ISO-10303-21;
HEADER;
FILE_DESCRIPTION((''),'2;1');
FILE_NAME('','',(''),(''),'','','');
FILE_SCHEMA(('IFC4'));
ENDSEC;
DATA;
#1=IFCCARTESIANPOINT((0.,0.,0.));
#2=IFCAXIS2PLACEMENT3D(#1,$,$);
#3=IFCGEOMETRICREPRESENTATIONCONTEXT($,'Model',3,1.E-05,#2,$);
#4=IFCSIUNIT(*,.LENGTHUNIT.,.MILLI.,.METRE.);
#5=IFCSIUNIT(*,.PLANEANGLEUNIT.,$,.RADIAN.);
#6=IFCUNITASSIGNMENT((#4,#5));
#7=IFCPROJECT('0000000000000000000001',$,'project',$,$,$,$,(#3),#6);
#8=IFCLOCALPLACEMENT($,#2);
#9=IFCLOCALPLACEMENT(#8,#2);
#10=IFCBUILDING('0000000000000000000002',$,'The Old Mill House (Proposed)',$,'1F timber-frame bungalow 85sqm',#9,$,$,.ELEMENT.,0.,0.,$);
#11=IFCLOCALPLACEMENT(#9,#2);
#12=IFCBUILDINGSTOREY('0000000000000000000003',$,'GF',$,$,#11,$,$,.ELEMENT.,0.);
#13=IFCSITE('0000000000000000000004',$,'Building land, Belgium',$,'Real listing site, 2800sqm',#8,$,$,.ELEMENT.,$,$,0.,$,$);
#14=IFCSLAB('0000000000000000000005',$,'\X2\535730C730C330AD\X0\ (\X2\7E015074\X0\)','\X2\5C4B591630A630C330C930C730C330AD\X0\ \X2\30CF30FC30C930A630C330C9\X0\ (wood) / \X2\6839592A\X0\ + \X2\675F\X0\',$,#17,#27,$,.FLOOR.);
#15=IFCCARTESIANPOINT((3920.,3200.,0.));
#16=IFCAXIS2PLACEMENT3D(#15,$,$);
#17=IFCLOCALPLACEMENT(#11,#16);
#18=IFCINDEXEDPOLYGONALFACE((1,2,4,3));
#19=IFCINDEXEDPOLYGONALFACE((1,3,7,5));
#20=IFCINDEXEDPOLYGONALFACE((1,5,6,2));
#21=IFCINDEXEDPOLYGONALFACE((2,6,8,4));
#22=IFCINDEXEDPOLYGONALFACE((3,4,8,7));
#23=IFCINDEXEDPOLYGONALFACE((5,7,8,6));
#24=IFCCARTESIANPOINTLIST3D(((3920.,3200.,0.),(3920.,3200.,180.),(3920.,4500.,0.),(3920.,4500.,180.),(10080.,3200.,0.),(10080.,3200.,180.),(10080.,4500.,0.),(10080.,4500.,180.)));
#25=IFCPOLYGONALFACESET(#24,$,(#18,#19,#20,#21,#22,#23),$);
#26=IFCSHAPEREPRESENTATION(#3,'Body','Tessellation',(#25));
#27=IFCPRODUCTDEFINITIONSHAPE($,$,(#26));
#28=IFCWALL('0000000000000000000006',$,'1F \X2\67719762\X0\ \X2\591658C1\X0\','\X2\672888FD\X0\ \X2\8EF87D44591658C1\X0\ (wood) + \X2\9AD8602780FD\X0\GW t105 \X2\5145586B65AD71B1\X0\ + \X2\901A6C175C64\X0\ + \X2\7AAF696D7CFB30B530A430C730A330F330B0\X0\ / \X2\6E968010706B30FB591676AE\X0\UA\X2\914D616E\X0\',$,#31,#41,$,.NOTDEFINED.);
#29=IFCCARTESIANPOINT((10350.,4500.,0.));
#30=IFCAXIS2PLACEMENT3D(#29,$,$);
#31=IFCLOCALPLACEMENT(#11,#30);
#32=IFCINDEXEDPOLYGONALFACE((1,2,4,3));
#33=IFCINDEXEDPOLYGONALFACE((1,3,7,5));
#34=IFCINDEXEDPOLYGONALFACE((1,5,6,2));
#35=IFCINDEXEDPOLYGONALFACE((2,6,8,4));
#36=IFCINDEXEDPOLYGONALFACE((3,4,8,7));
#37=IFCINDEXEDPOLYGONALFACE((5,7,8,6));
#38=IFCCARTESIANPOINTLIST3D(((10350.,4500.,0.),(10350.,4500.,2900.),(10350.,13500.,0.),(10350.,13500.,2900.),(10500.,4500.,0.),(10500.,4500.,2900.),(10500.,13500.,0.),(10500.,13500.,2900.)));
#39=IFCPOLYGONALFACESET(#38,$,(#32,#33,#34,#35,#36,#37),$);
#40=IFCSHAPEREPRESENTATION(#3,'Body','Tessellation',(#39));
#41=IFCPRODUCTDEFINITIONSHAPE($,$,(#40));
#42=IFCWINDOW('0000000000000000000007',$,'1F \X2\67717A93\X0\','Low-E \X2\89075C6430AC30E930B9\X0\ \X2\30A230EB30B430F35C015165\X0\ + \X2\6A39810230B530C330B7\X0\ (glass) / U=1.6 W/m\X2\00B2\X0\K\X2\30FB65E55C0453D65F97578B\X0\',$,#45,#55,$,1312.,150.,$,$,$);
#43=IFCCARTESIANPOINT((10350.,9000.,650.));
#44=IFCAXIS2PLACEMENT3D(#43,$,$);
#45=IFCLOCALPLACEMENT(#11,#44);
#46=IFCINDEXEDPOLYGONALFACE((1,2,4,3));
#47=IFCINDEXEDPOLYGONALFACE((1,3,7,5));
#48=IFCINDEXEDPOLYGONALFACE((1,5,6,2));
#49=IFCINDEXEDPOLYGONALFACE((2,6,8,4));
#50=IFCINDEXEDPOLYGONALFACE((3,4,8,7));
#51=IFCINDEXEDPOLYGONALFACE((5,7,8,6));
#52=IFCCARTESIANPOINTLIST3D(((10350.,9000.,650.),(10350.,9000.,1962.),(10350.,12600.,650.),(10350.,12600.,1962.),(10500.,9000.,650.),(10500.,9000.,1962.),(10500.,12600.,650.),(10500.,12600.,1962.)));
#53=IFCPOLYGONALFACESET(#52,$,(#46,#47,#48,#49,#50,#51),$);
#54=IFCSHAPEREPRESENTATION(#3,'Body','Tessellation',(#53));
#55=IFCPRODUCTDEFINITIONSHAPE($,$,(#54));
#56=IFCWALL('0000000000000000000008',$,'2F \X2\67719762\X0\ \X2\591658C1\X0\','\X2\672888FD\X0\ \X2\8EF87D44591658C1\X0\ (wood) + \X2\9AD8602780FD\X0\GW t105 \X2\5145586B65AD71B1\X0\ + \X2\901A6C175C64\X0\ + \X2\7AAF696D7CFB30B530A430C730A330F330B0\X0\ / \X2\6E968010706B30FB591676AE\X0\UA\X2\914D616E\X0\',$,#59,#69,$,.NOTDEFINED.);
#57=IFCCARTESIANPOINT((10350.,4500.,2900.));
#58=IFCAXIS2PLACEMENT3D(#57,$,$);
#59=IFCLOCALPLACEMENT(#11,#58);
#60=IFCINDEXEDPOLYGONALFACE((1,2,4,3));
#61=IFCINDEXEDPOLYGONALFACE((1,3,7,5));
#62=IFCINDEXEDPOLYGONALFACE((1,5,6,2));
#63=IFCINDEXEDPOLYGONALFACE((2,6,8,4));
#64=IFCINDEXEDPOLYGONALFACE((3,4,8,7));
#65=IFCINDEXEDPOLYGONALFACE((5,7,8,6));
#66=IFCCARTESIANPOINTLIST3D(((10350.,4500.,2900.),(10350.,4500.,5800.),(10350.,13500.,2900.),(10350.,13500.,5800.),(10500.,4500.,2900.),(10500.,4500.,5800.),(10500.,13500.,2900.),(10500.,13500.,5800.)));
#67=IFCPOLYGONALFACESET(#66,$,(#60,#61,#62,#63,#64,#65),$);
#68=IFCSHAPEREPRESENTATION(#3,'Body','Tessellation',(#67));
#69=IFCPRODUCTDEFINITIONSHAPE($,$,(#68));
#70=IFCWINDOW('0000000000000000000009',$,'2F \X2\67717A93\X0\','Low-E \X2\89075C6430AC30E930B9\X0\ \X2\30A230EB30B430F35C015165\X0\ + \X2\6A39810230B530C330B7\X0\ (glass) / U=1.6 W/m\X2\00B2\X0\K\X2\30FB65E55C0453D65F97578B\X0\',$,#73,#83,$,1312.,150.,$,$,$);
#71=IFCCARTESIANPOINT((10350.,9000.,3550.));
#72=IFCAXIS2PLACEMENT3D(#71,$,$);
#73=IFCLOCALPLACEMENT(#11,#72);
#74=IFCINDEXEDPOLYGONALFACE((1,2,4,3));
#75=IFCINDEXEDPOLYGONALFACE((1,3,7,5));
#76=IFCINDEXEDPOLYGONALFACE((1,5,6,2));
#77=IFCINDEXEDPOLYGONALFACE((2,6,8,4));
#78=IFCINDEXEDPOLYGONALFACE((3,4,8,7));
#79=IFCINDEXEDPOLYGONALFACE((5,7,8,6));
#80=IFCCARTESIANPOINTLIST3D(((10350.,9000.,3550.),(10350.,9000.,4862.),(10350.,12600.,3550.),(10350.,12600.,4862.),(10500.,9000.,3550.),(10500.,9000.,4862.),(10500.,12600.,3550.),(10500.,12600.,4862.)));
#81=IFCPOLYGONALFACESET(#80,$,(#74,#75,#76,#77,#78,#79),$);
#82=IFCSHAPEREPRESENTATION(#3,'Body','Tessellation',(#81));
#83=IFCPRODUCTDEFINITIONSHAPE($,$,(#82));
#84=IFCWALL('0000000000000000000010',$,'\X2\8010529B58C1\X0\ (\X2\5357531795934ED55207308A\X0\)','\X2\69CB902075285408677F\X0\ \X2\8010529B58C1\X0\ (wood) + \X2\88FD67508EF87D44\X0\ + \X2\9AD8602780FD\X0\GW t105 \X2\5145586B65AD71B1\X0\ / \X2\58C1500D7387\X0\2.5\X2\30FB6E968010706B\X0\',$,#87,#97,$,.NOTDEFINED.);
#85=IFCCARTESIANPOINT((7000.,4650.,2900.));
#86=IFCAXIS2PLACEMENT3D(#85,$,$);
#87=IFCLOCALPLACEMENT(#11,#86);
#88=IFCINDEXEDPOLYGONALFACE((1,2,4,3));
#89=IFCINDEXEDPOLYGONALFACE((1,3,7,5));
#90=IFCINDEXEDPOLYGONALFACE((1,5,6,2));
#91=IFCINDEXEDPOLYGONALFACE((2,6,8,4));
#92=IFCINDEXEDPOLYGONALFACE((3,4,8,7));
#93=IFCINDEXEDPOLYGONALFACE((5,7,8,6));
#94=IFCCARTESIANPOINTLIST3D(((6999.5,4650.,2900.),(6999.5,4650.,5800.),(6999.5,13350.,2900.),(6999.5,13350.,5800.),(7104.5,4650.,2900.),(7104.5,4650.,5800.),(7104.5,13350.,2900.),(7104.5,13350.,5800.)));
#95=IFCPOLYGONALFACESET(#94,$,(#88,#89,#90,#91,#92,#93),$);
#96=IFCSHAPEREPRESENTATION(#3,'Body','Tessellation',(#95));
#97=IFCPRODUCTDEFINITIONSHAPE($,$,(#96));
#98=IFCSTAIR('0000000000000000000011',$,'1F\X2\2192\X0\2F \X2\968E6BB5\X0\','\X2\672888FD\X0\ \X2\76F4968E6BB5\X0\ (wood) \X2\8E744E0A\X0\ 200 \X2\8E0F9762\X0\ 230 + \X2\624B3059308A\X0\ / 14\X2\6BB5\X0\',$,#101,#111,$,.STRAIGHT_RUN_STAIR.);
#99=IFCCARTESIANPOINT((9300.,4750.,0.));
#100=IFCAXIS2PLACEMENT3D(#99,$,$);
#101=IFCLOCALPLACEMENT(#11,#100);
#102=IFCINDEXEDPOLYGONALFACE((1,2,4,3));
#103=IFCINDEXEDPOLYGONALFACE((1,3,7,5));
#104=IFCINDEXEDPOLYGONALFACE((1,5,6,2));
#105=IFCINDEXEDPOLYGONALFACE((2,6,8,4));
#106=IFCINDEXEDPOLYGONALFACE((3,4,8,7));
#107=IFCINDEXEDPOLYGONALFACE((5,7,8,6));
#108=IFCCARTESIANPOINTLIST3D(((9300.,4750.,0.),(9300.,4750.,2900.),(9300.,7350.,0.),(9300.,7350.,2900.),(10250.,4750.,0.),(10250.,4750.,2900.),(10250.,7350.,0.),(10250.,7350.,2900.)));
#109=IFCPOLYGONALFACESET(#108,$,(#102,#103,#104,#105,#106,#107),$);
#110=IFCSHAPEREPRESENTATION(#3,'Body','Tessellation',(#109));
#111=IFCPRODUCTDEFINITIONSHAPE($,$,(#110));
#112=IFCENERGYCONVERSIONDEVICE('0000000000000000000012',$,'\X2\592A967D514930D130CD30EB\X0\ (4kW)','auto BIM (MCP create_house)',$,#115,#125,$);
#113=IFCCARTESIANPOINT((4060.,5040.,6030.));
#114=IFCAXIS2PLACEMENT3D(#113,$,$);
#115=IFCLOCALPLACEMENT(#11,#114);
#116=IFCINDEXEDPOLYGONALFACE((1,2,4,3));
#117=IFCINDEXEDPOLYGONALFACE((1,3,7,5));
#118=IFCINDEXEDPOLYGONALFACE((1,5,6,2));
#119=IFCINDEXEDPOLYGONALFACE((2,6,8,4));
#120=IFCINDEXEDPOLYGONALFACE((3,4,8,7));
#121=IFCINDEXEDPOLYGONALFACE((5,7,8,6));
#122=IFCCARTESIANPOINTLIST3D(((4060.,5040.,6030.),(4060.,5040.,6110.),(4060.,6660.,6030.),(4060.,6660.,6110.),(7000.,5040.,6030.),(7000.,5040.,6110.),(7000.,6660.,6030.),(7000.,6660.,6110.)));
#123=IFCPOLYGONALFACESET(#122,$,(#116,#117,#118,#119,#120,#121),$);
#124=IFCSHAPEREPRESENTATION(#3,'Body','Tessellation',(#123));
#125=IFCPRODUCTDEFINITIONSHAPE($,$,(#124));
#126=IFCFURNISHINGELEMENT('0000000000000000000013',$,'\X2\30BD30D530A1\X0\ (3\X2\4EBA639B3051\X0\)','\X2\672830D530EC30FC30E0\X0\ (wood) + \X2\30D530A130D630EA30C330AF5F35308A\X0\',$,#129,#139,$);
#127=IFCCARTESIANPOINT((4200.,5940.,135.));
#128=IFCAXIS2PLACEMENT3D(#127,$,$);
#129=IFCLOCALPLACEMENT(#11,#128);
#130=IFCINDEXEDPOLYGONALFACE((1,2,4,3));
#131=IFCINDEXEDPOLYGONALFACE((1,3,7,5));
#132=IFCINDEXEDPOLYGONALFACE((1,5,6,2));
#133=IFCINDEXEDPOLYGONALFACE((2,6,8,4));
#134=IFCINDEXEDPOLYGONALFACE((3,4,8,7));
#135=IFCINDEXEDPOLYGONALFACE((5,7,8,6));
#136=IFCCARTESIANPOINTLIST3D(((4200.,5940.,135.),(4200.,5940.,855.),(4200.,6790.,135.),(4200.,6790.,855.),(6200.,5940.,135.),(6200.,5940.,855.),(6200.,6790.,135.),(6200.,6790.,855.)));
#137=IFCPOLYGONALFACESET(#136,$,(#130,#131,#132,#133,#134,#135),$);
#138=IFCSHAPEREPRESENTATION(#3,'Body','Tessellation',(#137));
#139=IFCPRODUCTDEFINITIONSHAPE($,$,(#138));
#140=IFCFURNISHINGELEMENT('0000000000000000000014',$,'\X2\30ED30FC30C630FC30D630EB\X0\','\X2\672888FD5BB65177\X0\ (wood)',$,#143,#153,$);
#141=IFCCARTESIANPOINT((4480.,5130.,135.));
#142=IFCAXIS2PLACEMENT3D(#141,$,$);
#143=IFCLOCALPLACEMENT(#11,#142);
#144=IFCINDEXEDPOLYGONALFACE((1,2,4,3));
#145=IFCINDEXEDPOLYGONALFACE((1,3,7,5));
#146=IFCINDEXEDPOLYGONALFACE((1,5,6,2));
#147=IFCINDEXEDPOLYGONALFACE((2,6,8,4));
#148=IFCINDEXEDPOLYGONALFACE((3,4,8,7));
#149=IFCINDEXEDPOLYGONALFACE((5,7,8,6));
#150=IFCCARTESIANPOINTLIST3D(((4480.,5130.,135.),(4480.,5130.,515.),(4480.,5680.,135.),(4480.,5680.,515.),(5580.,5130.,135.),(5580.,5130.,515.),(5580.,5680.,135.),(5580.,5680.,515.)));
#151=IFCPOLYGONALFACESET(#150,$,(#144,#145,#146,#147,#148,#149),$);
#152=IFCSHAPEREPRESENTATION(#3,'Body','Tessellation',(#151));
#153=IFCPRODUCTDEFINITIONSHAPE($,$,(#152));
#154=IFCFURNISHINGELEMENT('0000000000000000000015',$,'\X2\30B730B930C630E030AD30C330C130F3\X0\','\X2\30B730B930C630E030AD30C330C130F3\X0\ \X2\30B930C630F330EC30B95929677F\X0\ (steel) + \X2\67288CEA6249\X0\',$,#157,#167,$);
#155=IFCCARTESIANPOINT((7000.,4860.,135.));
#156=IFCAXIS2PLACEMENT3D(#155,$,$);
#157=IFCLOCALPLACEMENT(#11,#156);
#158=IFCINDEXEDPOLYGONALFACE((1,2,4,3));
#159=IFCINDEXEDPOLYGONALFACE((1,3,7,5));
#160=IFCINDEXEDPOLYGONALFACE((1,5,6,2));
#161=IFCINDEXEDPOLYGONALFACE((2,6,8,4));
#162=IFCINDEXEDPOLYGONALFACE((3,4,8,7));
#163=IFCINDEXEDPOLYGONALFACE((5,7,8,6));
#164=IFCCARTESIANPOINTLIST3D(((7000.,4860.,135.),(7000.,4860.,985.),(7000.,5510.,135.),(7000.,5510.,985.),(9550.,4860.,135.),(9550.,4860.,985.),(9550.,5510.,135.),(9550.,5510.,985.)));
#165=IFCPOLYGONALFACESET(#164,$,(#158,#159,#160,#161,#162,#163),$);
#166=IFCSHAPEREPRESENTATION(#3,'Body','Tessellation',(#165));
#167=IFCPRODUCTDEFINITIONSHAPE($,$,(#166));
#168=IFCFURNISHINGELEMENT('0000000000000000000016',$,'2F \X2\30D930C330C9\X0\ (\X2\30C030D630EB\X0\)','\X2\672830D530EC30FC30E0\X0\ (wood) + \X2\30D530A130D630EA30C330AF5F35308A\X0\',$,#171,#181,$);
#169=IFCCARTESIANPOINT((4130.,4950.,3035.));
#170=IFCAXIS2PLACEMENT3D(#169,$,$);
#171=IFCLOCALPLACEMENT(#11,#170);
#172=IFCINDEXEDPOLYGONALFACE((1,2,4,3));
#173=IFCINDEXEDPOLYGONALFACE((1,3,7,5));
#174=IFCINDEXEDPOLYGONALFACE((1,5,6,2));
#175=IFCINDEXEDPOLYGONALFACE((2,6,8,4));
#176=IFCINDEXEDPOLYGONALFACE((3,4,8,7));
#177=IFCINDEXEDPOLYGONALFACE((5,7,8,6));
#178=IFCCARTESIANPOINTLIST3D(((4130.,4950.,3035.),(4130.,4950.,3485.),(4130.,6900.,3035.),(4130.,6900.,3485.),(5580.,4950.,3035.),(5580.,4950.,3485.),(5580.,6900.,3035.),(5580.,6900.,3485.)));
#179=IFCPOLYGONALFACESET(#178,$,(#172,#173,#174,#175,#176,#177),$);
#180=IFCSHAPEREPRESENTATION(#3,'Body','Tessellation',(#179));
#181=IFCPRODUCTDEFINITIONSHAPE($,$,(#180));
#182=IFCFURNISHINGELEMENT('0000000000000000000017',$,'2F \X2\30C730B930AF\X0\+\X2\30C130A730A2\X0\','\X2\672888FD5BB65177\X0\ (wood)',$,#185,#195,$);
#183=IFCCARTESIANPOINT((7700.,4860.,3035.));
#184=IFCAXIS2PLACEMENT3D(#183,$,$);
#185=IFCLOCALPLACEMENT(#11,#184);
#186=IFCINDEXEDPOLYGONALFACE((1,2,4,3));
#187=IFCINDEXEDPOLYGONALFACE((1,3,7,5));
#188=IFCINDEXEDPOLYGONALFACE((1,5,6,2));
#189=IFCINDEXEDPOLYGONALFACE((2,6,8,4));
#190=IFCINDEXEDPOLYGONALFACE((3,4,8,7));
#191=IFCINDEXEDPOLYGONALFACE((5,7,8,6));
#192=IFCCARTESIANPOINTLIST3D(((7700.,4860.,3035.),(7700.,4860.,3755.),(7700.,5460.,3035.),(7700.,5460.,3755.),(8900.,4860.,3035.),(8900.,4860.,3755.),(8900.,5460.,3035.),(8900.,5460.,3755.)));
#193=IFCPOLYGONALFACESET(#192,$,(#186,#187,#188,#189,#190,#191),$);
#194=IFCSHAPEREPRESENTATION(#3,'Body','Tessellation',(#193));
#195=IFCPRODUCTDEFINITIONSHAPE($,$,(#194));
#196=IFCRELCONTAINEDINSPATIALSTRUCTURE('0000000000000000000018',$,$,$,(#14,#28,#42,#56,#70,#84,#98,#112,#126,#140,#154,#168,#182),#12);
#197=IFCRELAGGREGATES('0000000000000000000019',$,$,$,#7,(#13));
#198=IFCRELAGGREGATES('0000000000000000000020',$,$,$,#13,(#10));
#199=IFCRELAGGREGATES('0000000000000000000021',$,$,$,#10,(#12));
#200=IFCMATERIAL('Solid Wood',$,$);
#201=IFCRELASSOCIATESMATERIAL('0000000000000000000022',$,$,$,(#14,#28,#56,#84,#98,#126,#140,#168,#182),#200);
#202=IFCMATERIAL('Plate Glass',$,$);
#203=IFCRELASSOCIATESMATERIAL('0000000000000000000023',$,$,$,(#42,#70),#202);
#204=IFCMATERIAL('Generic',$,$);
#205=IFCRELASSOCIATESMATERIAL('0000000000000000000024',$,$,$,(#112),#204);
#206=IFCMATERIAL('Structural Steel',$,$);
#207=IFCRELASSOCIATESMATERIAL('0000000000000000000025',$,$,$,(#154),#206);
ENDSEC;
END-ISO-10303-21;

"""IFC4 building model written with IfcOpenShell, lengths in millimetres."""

from ifc_helpers import new_model, si_unit, frame, frame_2d, origin, place, context, project, spatial, rectangle, extrude, material, element, fill, save


model = new_model("IFC4")

# Units and contexts
model_context = context("Model", 3, precision=1e-05, world=origin())
ifc_project = project(units=[si_unit("LENGTHUNIT", "METRE", prefix="MILLI"), si_unit("PLANEANGLEUNIT", "RADIAN")], contexts=[model_context])

# Site, building, storey
site_placement = place(None, origin())
site = spatial("IfcSite", under=ifc_project, at=site_placement, Name="Building land, Belgium", ObjectType="Real listing site, 2800sqm", CompositionType="ELEMENT", RefElevation=0.0)
building_placement = place(site_placement, origin())
building = spatial("IfcBuilding", under=site, at=building_placement, Name="The Old Mill House (Proposed)", ObjectType="1F timber-frame bungalow 85sqm", CompositionType="ELEMENT", ElevationOfRefHeight=0.0, ElevationOfTerrain=0.0)
storey_placement = place(building_placement, origin())
storey = spatial("IfcBuildingStorey", under=building, at=storey_placement, Name="GF", CompositionType="ELEMENT", Elevation=0.0)

# Slab
ifc_material_1 = material(Name="Solid Wood")
slab_placement = place(storey_placement, frame((3920.0, 3200.0, 0.0)))
element("IfcSlab", 1, at=slab_placement, inside=storey, material=ifc_material_1, Name="南デッキ (縁側)", Description="屋外ウッドデッキ ハードウッド (wood) / 根太 + 束", PredefinedType="FLOOR", context=model_context, shape_type="SweptSolid", body=[
    extrude(rectangle(XDim=6160.0, YDim=1300.0, at=frame_2d((3080.0, 650.0))), frame((3920.0, 3200.0, 0.0)), (0.0, 0.0, 1.0), 180.0),
])

# Wall, opening, window
wall_1_placement = place(storey_placement, frame((10350.0, 4500.0, 0.0)))
wall_1 = element("IfcWall", 2, at=wall_1_placement, inside=storey, material=ifc_material_1, Name="1F 東面 外壁", Description="木製 軸組外壁 (wood) + 高性能GW t105 充填断熱 + 通気層 + 窯業系サイディング / 準耐火・外皮UA配慮", PredefinedType="NOTDEFINED", context=model_context, shape_type="SweptSolid", body=[
    extrude(rectangle(XDim=150.0, YDim=9000.0, at=frame_2d((75.0, 4500.0))), frame((10350.0, 4500.0, 0.0)), (0.0, 0.0, 1.0), 2900.0),
])
opening_1_placement = place(storey_placement, frame((10350.0, 9000.0, 650.0)))
opening_1 = element("IfcOpeningElement", 3, at=opening_1_placement, cuts=wall_1, PredefinedType="NOTDEFINED", context=model_context, shape_type="SweptSolid", body=[
    extrude(rectangle(XDim=150.0, YDim=3600.0, at=frame_2d((75.0, 1800.0))), frame((10350.0, 9000.0, 650.0)), (0.0, 0.0, 1.0), 1312.0),
])
ifc_material_2 = material(Name="Plate Glass")
window_1_placement = place(storey_placement, frame((10350.0, 9000.0, 650.0)))
window_1 = element("IfcWindow", 4, at=window_1_placement, inside=storey, material=ifc_material_2, Name="1F 東窓", Description="Low-E 複層ガラス アルゴン封入 + 樹脂サッシ (glass) / U=1.6 W/m²K・日射取得型", OverallHeight=1312.0, OverallWidth=150.0, context=model_context, shape_type="SweptSolid", body=[
    extrude(rectangle(XDim=150.0, YDim=3600.0, at=frame_2d((75.0, 1800.0))), frame((10350.0, 9000.0, 650.0)), (0.0, 0.0, 1.0), 1312.0),
])
fill(opening_1, window_1)

# Wall, opening, window
wall_2_placement = place(storey_placement, frame((10350.0, 4500.0, 2900.0)))
wall_2 = element("IfcWall", 5, at=wall_2_placement, inside=storey, material=ifc_material_1, Name="2F 東面 外壁", Description="木製 軸組外壁 (wood) + 高性能GW t105 充填断熱 + 通気層 + 窯業系サイディング / 準耐火・外皮UA配慮", PredefinedType="NOTDEFINED", context=model_context, shape_type="SweptSolid", body=[
    extrude(rectangle(XDim=150.0, YDim=9000.0, at=frame_2d((75.0, 4500.0))), frame((10350.0, 4500.0, 2900.0)), (0.0, 0.0, 1.0), 2900.0),
])
opening_2_placement = place(storey_placement, frame((10350.0, 9000.0, 3550.0)))
opening_2 = element("IfcOpeningElement", 6, at=opening_2_placement, cuts=wall_2, PredefinedType="NOTDEFINED", context=model_context, shape_type="SweptSolid", body=[
    extrude(rectangle(XDim=150.0, YDim=3600.0, at=frame_2d((75.0, 1800.0))), frame((10350.0, 9000.0, 3550.0)), (0.0, 0.0, 1.0), 1312.0),
])
window_2_placement = place(storey_placement, frame((10350.0, 9000.0, 3550.0)))
window_2 = element("IfcWindow", 7, at=window_2_placement, inside=storey, material=ifc_material_2, Name="2F 東窓", Description="Low-E 複層ガラス アルゴン封入 + 樹脂サッシ (glass) / U=1.6 W/m²K・日射取得型", OverallHeight=1312.0, OverallWidth=150.0, context=model_context, shape_type="SweptSolid", body=[
    extrude(rectangle(XDim=150.0, YDim=3600.0, at=frame_2d((75.0, 1800.0))), frame((10350.0, 9000.0, 3550.0)), (0.0, 0.0, 1.0), 1312.0),
])
fill(opening_2, window_2)

# Wall
wall_3_placement = place(storey_placement, frame((7000.0, 4650.0, 2900.0)))
element("IfcWall", 8, at=wall_3_placement, inside=storey, material=ifc_material_1, Name="耐力壁 (南北間仕切り)", Description="構造用合板 耐力壁 (wood) + 製材軸組 + 高性能GW t105 充填断熱 / 壁倍率2.5・準耐火", PredefinedType="NOTDEFINED", context=model_context, shape_type="SweptSolid", body=[
    extrude(rectangle(XDim=105.0, YDim=8700.0, at=frame_2d((52.0, 4350.0))), frame((7000.0, 4650.0, 2900.0)), (0.0, 0.0, 1.0), 2900.0),
])

# Stair
stair_placement = place(storey_placement, frame((9300.0, 4750.0, 0.0)))
element("IfcStair", 9, at=stair_placement, inside=storey, material=ifc_material_1, Name="1F→2F 階段", Description="木製 直階段 (wood) 蹴上 200 踏面 230 + 手すり / 14段", PredefinedType="STRAIGHT_RUN_STAIR", context=model_context, shape_type="SweptSolid", body=[
    extrude(rectangle(XDim=950.0, YDim=2600.0, at=frame_2d((475.0, 1300.0))), frame((9300.0, 4750.0, 0.0)), (0.0, 0.0, 1.0), 2900.0),
])

# Energy conversion device
ifc_material_3 = material(Name="Generic")
energy_conversion_device_placement = place(storey_placement, frame((4060.0, 5040.0, 6030.0)))
element("IfcEnergyConversionDevice", 10, at=energy_conversion_device_placement, inside=storey, material=ifc_material_3, Name="太陽光パネル (4kW)", Description="auto BIM (MCP create_house)", context=model_context, shape_type="SweptSolid", body=[
    extrude(rectangle(XDim=2940.0, YDim=1620.0, at=frame_2d((1470.0, 810.0))), frame((4060.0, 5040.0, 6030.0)), (0.0, 0.0, 1.0), 80.0),
])

# Furnishing elements
furnishing_1_placement = place(storey_placement, frame((4200.0, 5940.0, 135.0)))
element("IfcFurnishingElement", 11, at=furnishing_1_placement, inside=storey, material=ifc_material_1, Name="ソファ (3人掛け)", Description="木フレーム (wood) + ファブリック張り", context=model_context, shape_type="SweptSolid", body=[
    extrude(rectangle(XDim=2000.0, YDim=850.0, at=frame_2d((1000.0, 425.0))), frame((4200.0, 5940.0, 135.0)), (0.0, 0.0, 1.0), 720.0),
])
furnishing_2_placement = place(storey_placement, frame((4480.0, 5130.0, 135.0)))
element("IfcFurnishingElement", 12, at=furnishing_2_placement, inside=storey, material=ifc_material_1, Name="ローテーブル", Description="木製家具 (wood)", context=model_context, shape_type="SweptSolid", body=[
    extrude(rectangle(XDim=1100.0, YDim=550.0, at=frame_2d((550.0, 275.0))), frame((4480.0, 5130.0, 135.0)), (0.0, 0.0, 1.0), 380.0),
])
ifc_material_4 = material(Name="Structural Steel")
furnishing_3_placement = place(storey_placement, frame((7000.0, 4860.0, 135.0)))
element("IfcFurnishingElement", 13, at=furnishing_3_placement, inside=storey, material=ifc_material_4, Name="システムキッチン", Description="システムキッチン ステンレス天板 (steel) + 木質扉", context=model_context, shape_type="SweptSolid", body=[
    extrude(rectangle(XDim=2550.0, YDim=650.0, at=frame_2d((1275.0, 325.0))), frame((7000.0, 4860.0, 135.0)), (0.0, 0.0, 1.0), 850.0),
])
furnishing_4_placement = place(storey_placement, frame((4130.0, 4950.0, 3035.0)))
element("IfcFurnishingElement", 14, at=furnishing_4_placement, inside=storey, material=ifc_material_1, Name="2F ベッド (ダブル)", Description="木フレーム (wood) + ファブリック張り", context=model_context, shape_type="SweptSolid", body=[
    extrude(rectangle(XDim=1450.0, YDim=1950.0, at=frame_2d((725.0, 975.0))), frame((4130.0, 4950.0, 3035.0)), (0.0, 0.0, 1.0), 450.0),
])
furnishing_5_placement = place(storey_placement, frame((7700.0, 4860.0, 3035.0)))
element("IfcFurnishingElement", 15, at=furnishing_5_placement, inside=storey, material=ifc_material_1, Name="2F デスク+チェア", Description="木製家具 (wood)", context=model_context, shape_type="SweptSolid", body=[
    extrude(rectangle(XDim=1200.0, YDim=600.0, at=frame_2d((600.0, 300.0))), frame((7700.0, 4860.0, 3035.0)), (0.0, 0.0, 1.0), 720.0),
])

save(model, "model.ifc")
